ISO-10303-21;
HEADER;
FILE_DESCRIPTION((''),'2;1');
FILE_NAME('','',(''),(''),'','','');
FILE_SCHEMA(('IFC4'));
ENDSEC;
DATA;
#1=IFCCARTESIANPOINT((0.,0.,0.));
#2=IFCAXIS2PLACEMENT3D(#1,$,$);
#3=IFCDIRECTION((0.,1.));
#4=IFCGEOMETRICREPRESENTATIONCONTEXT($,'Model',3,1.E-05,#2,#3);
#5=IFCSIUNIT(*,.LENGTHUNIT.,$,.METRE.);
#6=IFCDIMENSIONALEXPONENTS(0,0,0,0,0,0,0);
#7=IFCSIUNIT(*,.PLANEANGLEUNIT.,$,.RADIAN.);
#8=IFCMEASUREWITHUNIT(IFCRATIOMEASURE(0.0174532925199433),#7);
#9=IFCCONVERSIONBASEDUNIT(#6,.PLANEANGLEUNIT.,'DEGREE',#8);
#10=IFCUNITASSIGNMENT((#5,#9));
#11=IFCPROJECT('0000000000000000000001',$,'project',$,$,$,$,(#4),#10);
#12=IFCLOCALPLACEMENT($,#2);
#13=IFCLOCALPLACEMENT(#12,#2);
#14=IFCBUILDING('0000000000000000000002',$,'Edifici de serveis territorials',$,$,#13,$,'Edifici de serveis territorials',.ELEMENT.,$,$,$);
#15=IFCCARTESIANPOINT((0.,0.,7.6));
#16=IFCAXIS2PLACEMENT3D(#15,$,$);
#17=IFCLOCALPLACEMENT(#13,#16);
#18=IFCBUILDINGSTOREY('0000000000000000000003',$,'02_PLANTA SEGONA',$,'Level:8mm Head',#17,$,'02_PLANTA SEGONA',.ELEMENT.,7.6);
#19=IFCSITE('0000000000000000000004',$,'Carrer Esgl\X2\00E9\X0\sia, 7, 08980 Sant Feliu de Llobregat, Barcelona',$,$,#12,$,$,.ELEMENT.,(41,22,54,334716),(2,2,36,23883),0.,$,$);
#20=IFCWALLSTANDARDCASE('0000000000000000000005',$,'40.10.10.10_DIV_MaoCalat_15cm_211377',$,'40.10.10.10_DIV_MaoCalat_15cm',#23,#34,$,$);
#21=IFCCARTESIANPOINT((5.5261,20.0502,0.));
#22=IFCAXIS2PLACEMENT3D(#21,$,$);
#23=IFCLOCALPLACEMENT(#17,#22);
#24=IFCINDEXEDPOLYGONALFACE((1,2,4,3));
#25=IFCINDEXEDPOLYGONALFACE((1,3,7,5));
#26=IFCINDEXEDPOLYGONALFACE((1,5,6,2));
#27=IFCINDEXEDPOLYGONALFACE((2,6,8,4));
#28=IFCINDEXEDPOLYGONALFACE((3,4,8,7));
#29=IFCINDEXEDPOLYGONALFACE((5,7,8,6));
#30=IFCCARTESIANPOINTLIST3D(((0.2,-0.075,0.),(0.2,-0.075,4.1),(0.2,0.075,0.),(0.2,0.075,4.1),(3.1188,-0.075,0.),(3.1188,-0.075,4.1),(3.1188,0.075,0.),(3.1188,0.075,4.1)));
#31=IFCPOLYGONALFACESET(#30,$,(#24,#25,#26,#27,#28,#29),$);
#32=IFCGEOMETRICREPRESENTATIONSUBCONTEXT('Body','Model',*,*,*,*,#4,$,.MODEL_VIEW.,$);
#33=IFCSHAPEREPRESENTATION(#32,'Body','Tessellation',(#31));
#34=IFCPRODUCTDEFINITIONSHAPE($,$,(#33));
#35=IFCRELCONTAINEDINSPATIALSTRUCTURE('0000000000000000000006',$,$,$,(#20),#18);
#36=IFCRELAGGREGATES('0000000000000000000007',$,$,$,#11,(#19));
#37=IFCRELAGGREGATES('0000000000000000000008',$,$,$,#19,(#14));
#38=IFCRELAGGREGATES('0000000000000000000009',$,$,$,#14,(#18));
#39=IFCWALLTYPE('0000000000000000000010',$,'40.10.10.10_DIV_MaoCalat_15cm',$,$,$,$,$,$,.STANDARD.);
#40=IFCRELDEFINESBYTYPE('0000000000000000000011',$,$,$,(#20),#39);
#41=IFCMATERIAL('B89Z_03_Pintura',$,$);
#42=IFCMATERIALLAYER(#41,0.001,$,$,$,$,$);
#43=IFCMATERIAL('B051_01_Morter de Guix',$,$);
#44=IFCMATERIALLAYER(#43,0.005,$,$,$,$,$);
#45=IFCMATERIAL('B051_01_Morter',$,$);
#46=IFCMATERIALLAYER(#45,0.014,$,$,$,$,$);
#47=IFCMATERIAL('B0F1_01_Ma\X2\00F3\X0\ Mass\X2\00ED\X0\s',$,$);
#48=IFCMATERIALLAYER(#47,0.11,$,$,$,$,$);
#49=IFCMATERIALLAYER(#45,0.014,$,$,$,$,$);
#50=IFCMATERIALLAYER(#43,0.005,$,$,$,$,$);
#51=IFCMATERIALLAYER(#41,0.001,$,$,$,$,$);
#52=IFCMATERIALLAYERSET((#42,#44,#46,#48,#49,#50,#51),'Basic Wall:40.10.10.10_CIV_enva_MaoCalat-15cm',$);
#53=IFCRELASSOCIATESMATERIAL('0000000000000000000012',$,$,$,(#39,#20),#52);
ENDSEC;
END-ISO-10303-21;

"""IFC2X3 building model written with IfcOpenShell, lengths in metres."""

from ifc_helpers import new_model, entity, si_unit, converted_unit, direction, frame, frame_2d, origin, place, context, subcontext, project, spatial, rectangle, extrude, material, layer, layer_set, layer_usage, type_object, element, save


model = new_model("IFC2X3")

# Units and contexts
model_context = context("Model", 3, precision=1e-05, world=origin(), true_north=direction((0.0, 1.0)))
body_context = subcontext(model_context, "Body", "Model", "MODEL_VIEW")
ifc_project = project(units=[si_unit("LENGTHUNIT", "METRE"), converted_unit("PLANEANGLEUNIT", "DEGREE", entity("IfcRatioMeasure", 0.0174532925199433), si_unit("PLANEANGLEUNIT", "RADIAN"), dimensions=[0, 0, 0, 0, 0, 0, 0])], contexts=[model_context])

# Site, building, storey
site_placement = place(None, origin())
site = spatial("IfcSite", under=ifc_project, at=site_placement, Name="Carrer Església, 7, 08980 Sant Feliu de Llobregat, Barcelona", CompositionType="ELEMENT", RefLatitude=(41, 22, 54, 334716), RefLongitude=(2, 2, 36, 23883), RefElevation=0.0)
building_placement = place(site_placement, origin())
building = spatial("IfcBuilding", under=site, at=building_placement, Name="Edifici de serveis territorials", LongName="Edifici de serveis territorials", CompositionType="ELEMENT")
storey_placement = place(building_placement, frame((0.0, 0.0, 7.6)))
storey = spatial("IfcBuildingStorey", under=building, at=storey_placement, Name="02_PLANTA SEGONA", ObjectType="Level:8mm Head", LongName="02_PLANTA SEGONA", CompositionType="ELEMENT", Elevation=7.6)

# Shared definitions
ifc_material_1 = material(Name="B89Z_03_Pintura")

# Wall
ifc_layer_1 = layer(ifc_material_1, 0.001)
ifc_material_2 = material(Name="B051_01_Morter de Guix")
ifc_layer_2 = layer(ifc_material_2, 0.005)
ifc_material_3 = material(Name="B051_01_Morter")
ifc_layer_3 = layer(ifc_material_3, 0.014)
ifc_material_4 = material(Name="B0F1_01_Maó Massís")
ifc_layer_4 = layer(ifc_material_4, 0.11)
ifc_layer_5 = layer(ifc_material_3, 0.014)
ifc_layer_6 = layer(ifc_material_2, 0.005)
ifc_layer_7 = layer(ifc_material_1, 0.001)
ifc_layer_set_1 = layer_set([ifc_layer_1, ifc_layer_2, ifc_layer_3, ifc_layer_4, ifc_layer_5, ifc_layer_6, ifc_layer_7], Name="Basic Wall:40.10.10.10_CIV_enva_MaoCalat-15cm")
wall_type_1 = type_object("IfcWallType", Name="40.10.10.10_DIV_MaoCalat_15cm", PredefinedType="STANDARD", material=ifc_layer_set_1)
ifc_layer_usage_1 = layer_usage(ifc_layer_set_1, "AXIS2", "NEGATIVE", 0.075)
wall_1_placement = place(storey_placement, frame((5.5261, 20.0502, 0.0)))
element("IfcWallStandardCase", 1, at=wall_1_placement, inside=storey, type_object=wall_type_1, material=ifc_layer_usage_1, Name="40.10.10.10_DIV_MaoCalat_15cm_211377", ObjectType="40.10.10.10_DIV_MaoCalat_15cm", context=body_context, shape_type="SweptSolid", body=[
    extrude(rectangle(XDim=2.9188, YDim=0.15, at=frame_2d((1.6594, 0.0), x_axis=(-1.0, 0.0))), origin(), (0.0, 0.0, 1.0), 4.1),
])

save(model, "model.ifc")
